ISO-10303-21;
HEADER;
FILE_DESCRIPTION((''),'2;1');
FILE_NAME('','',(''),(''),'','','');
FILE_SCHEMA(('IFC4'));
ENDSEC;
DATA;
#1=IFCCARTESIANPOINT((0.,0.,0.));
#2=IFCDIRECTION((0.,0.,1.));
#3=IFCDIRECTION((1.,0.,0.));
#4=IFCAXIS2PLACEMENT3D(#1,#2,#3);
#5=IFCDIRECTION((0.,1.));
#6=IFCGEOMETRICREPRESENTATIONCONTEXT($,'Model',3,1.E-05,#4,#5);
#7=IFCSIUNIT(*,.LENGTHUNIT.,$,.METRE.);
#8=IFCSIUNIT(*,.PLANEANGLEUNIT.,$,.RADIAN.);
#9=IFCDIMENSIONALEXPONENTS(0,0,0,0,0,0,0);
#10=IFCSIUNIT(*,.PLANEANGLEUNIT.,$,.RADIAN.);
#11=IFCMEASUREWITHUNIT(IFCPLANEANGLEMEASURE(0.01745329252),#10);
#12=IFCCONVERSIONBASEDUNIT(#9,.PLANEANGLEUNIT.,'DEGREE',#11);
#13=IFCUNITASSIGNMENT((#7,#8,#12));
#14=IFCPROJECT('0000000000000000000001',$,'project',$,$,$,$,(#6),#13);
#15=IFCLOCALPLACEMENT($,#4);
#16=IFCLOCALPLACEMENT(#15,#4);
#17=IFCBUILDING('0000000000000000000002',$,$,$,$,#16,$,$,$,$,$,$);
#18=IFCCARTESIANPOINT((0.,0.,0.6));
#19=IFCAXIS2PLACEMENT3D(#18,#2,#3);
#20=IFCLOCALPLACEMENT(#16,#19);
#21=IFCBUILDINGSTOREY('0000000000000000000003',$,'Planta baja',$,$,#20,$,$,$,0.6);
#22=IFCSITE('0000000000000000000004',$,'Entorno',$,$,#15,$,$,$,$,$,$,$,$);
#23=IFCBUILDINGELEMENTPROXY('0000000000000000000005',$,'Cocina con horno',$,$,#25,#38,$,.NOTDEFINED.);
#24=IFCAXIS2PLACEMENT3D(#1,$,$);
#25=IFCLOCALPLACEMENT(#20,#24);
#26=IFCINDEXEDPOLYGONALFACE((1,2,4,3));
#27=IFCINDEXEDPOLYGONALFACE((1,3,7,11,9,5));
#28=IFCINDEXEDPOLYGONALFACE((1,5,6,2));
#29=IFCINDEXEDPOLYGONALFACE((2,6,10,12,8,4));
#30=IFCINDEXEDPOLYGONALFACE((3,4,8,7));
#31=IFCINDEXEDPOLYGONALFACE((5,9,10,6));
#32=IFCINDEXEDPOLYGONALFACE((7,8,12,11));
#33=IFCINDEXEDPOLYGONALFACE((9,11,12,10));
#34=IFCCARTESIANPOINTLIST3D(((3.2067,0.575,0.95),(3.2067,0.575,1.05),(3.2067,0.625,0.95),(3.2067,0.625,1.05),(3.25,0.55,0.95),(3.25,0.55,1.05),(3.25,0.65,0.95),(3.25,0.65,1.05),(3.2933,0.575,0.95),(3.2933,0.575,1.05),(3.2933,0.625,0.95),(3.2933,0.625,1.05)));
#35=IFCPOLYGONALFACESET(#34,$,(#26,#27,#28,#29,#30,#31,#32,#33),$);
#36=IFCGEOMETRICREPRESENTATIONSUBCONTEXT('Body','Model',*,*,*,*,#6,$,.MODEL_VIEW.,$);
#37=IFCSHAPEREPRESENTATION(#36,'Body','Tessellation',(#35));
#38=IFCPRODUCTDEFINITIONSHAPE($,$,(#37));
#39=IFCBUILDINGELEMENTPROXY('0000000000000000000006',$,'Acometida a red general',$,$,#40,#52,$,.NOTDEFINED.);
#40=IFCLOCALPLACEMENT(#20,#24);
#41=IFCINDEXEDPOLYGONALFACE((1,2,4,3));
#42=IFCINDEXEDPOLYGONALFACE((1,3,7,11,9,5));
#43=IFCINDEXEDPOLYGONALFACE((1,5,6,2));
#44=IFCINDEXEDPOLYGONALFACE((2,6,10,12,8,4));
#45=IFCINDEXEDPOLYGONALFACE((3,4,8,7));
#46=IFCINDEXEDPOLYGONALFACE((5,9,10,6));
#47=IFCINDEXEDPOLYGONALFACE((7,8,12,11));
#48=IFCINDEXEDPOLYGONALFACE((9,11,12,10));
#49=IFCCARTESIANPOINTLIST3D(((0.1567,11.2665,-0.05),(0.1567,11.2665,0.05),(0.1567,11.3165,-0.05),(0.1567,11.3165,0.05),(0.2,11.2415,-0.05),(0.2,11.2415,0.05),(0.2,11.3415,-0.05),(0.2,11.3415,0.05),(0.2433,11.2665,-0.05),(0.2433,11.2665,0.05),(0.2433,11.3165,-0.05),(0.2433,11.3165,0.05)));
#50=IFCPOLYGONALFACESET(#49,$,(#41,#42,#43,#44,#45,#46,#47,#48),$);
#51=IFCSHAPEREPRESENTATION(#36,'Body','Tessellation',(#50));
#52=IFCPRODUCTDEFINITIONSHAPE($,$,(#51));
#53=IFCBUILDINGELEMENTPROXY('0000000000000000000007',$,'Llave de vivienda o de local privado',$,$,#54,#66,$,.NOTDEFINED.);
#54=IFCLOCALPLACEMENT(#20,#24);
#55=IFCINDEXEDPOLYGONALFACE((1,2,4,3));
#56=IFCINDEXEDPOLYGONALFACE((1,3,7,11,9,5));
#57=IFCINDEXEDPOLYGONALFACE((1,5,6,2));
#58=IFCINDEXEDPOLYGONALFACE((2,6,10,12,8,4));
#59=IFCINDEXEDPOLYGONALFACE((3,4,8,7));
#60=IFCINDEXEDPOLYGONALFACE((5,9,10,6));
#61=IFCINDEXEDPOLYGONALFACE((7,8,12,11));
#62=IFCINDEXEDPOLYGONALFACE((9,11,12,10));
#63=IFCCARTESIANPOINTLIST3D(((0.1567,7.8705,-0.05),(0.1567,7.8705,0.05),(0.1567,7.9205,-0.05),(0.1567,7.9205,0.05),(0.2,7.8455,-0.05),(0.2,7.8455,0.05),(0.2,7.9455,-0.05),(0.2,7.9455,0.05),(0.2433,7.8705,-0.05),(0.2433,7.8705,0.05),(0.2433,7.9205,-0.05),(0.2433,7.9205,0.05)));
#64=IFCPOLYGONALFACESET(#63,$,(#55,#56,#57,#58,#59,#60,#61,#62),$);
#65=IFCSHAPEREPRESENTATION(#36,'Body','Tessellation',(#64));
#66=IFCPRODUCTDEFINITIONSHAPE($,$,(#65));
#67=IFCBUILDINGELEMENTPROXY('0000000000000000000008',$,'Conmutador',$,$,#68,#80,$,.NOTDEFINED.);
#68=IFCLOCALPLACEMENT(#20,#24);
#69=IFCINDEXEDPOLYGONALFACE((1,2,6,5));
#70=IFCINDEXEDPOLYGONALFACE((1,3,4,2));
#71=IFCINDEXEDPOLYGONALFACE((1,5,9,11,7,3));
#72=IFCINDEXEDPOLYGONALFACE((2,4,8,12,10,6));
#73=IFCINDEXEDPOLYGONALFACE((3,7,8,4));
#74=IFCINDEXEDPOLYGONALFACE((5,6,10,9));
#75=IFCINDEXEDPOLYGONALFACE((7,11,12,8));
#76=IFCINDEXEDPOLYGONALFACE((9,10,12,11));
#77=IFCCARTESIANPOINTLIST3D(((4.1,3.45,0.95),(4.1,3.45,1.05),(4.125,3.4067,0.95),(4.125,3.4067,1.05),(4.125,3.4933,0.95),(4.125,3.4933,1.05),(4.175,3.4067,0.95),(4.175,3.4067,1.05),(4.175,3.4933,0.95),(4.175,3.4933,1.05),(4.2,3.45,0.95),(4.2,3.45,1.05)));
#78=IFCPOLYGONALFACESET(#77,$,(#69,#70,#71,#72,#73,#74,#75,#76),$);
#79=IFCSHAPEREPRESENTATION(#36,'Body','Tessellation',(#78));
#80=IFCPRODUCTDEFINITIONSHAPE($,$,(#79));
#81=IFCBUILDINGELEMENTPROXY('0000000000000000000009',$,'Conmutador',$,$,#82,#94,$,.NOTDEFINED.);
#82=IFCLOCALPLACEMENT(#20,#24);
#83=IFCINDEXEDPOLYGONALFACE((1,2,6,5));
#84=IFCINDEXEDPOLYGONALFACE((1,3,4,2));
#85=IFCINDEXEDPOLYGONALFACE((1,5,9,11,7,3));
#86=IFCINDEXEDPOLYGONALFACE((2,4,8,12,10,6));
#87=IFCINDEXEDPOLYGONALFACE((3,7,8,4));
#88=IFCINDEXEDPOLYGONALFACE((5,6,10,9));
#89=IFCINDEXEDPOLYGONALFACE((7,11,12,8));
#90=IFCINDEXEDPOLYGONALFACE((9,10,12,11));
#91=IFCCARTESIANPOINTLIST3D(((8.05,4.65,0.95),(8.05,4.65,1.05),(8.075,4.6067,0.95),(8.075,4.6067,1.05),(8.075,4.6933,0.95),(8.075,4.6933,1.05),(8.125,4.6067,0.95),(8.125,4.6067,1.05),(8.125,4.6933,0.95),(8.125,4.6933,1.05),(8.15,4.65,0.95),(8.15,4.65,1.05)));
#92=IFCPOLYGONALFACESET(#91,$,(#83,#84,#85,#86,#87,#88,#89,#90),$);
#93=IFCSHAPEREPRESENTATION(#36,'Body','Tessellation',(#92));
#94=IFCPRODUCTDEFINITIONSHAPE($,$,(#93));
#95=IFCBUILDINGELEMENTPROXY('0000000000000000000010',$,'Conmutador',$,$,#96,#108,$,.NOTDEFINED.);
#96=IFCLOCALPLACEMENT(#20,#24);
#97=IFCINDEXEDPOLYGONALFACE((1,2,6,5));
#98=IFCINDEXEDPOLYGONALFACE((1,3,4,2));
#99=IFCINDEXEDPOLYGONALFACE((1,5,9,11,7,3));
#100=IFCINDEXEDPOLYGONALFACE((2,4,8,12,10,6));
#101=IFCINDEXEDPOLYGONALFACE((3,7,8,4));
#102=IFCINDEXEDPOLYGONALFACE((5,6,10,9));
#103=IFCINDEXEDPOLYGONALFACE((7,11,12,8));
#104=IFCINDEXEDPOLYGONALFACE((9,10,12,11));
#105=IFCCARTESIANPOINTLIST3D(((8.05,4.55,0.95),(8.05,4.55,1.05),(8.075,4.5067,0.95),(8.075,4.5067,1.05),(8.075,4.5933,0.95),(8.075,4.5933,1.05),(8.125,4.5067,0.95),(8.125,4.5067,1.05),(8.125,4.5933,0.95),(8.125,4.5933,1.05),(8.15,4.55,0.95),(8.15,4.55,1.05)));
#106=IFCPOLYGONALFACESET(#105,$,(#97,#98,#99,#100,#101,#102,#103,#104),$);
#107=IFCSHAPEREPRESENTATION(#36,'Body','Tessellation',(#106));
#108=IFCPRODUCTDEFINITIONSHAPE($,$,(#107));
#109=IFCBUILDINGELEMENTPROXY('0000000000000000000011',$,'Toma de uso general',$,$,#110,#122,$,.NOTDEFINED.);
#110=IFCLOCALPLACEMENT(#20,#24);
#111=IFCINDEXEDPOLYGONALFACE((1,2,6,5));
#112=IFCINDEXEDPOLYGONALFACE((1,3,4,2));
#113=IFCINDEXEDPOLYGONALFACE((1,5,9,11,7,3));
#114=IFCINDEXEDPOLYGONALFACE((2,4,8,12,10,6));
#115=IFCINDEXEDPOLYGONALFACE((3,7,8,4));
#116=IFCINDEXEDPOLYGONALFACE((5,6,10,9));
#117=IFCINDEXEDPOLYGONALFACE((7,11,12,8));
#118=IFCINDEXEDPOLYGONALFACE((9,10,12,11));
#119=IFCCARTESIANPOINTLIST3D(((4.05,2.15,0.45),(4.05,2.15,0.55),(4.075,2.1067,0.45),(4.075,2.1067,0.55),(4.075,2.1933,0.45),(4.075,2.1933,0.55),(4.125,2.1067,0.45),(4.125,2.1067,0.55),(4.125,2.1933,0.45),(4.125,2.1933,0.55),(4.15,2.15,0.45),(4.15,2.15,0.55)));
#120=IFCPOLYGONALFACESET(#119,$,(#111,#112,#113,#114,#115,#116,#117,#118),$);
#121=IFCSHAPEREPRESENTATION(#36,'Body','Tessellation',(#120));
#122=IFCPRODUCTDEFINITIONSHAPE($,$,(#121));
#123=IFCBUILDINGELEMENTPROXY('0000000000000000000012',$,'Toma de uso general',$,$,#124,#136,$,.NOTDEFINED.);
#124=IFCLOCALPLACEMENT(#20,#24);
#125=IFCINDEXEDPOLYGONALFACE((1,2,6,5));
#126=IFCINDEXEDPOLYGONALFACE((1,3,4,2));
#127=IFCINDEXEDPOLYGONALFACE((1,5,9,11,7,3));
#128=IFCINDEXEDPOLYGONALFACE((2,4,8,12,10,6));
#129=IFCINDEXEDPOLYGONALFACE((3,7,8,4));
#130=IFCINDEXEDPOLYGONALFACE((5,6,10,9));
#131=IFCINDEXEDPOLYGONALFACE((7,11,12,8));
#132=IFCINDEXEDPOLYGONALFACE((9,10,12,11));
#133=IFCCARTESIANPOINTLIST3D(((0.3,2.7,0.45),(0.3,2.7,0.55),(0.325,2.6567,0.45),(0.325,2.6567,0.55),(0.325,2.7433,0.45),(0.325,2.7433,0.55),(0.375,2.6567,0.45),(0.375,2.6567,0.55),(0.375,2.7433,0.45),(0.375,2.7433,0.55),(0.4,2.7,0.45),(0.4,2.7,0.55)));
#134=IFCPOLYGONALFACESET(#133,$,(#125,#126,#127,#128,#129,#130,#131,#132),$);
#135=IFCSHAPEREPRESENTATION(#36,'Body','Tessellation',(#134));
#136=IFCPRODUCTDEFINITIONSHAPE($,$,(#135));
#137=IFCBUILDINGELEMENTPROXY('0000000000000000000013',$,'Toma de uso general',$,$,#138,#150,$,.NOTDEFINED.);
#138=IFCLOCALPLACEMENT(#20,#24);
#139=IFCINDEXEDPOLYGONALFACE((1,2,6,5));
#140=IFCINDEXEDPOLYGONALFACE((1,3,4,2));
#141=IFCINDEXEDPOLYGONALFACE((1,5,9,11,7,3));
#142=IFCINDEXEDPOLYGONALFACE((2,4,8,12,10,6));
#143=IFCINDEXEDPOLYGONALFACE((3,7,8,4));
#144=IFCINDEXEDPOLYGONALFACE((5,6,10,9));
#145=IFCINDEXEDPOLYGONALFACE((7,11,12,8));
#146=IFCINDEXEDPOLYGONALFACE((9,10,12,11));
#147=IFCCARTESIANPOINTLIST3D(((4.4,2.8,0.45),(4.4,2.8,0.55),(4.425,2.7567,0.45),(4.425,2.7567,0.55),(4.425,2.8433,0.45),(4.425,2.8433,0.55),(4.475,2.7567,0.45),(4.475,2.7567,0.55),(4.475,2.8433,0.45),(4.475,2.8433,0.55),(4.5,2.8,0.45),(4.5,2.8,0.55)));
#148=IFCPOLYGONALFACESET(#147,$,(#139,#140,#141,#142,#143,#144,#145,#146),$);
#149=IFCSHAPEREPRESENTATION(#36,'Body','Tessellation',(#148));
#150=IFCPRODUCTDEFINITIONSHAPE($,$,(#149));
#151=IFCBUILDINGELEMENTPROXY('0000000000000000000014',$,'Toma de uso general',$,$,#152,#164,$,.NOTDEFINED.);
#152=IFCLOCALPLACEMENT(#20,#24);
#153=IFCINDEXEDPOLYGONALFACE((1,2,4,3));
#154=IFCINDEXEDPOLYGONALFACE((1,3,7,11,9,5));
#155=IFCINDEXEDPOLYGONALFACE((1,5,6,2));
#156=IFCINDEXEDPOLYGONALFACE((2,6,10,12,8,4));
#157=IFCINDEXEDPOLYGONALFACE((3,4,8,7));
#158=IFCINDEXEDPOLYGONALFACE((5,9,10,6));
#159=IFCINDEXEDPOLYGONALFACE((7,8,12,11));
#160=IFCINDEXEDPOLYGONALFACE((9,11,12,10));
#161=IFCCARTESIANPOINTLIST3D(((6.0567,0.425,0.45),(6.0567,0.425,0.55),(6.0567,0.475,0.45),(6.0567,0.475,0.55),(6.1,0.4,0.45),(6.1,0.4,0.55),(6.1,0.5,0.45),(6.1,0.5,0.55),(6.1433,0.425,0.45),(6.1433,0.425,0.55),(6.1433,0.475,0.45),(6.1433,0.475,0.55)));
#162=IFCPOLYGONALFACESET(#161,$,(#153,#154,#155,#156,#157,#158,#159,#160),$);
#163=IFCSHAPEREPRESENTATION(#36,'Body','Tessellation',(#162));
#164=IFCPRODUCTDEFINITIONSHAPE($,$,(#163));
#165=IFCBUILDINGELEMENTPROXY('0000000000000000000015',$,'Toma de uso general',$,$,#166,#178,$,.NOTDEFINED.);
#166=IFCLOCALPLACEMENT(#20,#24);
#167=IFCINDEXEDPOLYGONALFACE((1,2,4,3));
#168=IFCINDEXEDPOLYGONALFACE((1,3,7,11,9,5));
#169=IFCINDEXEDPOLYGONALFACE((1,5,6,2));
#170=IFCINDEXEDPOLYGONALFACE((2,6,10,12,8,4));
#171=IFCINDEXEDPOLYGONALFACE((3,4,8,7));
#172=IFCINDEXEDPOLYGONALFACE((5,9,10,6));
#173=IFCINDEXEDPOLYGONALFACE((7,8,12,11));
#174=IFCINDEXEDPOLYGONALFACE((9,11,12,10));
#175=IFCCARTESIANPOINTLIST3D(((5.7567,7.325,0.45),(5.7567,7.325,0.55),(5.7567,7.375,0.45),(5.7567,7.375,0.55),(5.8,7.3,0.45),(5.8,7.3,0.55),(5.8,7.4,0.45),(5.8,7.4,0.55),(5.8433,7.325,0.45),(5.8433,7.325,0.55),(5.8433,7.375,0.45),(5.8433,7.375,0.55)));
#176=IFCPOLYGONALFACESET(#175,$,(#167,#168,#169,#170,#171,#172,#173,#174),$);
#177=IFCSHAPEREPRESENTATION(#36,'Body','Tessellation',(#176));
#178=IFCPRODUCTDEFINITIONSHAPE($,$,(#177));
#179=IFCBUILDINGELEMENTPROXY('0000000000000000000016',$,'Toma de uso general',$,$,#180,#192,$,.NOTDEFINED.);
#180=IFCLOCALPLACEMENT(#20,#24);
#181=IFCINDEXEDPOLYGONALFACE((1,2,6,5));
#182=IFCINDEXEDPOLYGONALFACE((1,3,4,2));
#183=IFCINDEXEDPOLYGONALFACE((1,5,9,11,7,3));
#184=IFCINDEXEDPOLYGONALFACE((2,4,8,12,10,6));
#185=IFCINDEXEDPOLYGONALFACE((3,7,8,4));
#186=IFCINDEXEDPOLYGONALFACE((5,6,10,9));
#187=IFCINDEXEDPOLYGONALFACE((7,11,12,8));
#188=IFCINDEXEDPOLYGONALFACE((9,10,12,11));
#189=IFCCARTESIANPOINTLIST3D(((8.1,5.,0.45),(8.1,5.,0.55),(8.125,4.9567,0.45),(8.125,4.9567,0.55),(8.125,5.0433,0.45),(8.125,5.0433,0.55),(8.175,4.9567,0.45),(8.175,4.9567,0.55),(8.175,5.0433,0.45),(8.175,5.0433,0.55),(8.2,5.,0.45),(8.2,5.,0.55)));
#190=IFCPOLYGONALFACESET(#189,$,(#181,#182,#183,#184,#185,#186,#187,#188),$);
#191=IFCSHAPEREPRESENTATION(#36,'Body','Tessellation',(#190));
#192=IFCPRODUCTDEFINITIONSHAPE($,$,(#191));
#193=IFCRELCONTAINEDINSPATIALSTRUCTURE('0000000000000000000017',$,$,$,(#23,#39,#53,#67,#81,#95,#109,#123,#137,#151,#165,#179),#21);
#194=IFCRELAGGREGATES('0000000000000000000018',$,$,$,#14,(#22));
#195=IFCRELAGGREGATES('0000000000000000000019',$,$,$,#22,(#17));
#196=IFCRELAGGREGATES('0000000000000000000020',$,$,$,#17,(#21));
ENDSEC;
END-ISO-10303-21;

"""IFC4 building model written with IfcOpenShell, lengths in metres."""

from ifc_helpers import new_model, entity, si_unit, converted_unit, direction, frame, origin_with_axes, place, context, subcontext, project, spatial, polyline, outline, extrude, source, transform, mapped, element, save


model = new_model("IFC4")

# Units and contexts
model_context = context("Model", 3, precision=1e-05, world=origin_with_axes(), true_north=direction((0.0, 1.0)))
body_context = subcontext(model_context, "Body", "Model", "MODEL_VIEW")
ifc_project = project(units=[si_unit("LENGTHUNIT", "METRE"), si_unit("PLANEANGLEUNIT", "RADIAN"), converted_unit("PLANEANGLEUNIT", "DEGREE", entity("IfcPlaneAngleMeasure", 0.01745329252), si_unit("PLANEANGLEUNIT", "RADIAN"), dimensions=[0, 0, 0, 0, 0, 0, 0])], contexts=[model_context])

# Site, building, storey
site_placement = place(None, origin_with_axes())
site = spatial("IfcSite", under=ifc_project, at=site_placement, Name="Entorno")
building_placement = place(site_placement, origin_with_axes())
building = spatial("IfcBuilding", under=site, at=building_placement)
storey_placement = place(building_placement, frame((0.0, 0.0, 0.6), z_axis=(0.0, 0.0, 1.0), x_axis=(1.0, 0.0, 0.0)))
storey = spatial("IfcBuildingStorey", under=building, at=storey_placement, Name="Planta baja", Elevation=0.6)

# Building element proxies
shared_shape_1 = source(origin_with_axes(), body_context, "Body", "SolidModel", [
    extrude(outline(polyline([(0.05, 0.0), (0.025, 0.0433), (-0.025, 0.0433), (-0.05, 0.0), (-0.025, -0.0433), (0.025, -0.0433), (0.05, 0.0)])), frame((0.0, 0.0, -0.05), z_axis=(0.0, 0.0, 1.0), x_axis=(1.0, 0.0, 0.0)), (0.0, 0.0, 1.0), 0.1),
])
proxy_1_placement = place(storey_placement, frame((0.0, 0.0, -0.6), z_axis=(0.0, 0.0, 1.0), x_axis=(1.0, 0.0, 0.0)))
element("IfcBuildingElementProxy", 1, at=proxy_1_placement, inside=storey, Name="Cocina con horno", PredefinedType="NOTDEFINED", context=body_context, shape_type="Brep", body=[
    mapped(shared_shape_1, transform((3.25, 0.6, 1.6), x_axis=(0.0, 1.0, 0.0), y_axis=(-1.0, 0.0, 0.0), z_axis=(0.0, 0.0, 1.0))),
])
shared_shape_2 = source(origin_with_axes(), body_context, "Body", "SolidModel", [
    extrude(outline(polyline([(0.05, 0.0), (0.025, 0.0433), (-0.025, 0.0433), (-0.05, 0.0), (-0.025, -0.0433), (0.025, -0.0433), (0.05, 0.0)])), frame((0.0, 0.0, -0.05), z_axis=(0.0, 0.0, 1.0), x_axis=(1.0, 0.0, 0.0)), (0.0, 0.0, 1.0), 0.1),
])
proxy_2_placement = place(storey_placement, frame((0.0, 0.0, -0.6), z_axis=(0.0, 0.0, 1.0), x_axis=(1.0, 0.0, 0.0)))
element("IfcBuildingElementProxy", 2, at=proxy_2_placement, inside=storey, Name="Acometida a red general", PredefinedType="NOTDEFINED", context=body_context, shape_type="Brep", body=[
    mapped(shared_shape_2, transform((0.2, 11.2915, 0.6), x_axis=(0.0, -1.0, 0.0), y_axis=(1.0, 0.0, 0.0), z_axis=(0.0, 0.0, 1.0))),
])
shared_shape_3 = source(origin_with_axes(), body_context, "Body", "SolidModel", [
    extrude(outline(polyline([(0.05, 0.0), (0.025, 0.0433), (-0.025, 0.0433), (-0.05, 0.0), (-0.025, -0.0433), (0.025, -0.0433), (0.05, 0.0)])), frame((0.0, 0.0, -0.05), z_axis=(0.0, 0.0, 1.0), x_axis=(1.0, 0.0, 0.0)), (0.0, 0.0, 1.0), 0.1),
])
proxy_3_placement = place(storey_placement, frame((0.0, 0.0, -0.6), z_axis=(0.0, 0.0, 1.0), x_axis=(1.0, 0.0, 0.0)))
element("IfcBuildingElementProxy", 3, at=proxy_3_placement, inside=storey, Name="Llave de vivienda o de local privado", PredefinedType="NOTDEFINED", context=body_context, shape_type="Brep", body=[
    mapped(shared_shape_3, transform((0.2, 7.8955, 0.6), x_axis=(0.0, -1.0, 0.0), y_axis=(1.0, 0.0, 0.0), z_axis=(0.0, 0.0, 1.0))),
])
shared_shape_4 = source(origin_with_axes(), body_context, "Body", "SolidModel", [
    extrude(outline(polyline([(0.05, 0.0), (0.025, 0.0433), (-0.025, 0.0433), (-0.05, 0.0), (-0.025, -0.0433), (0.025, -0.0433), (0.05, 0.0)])), frame((0.0, 0.0, -0.05), z_axis=(0.0, 0.0, 1.0), x_axis=(1.0, 0.0, 0.0)), (0.0, 0.0, 1.0), 0.1),
])
proxy_4_placement = place(storey_placement, frame((0.0, 0.0, -0.6), z_axis=(0.0, 0.0, 1.0), x_axis=(1.0, 0.0, 0.0)))
element("IfcBuildingElementProxy", 4, at=proxy_4_placement, inside=storey, Name="Conmutador", PredefinedType="NOTDEFINED", context=body_context, shape_type="Brep", body=[
    mapped(shared_shape_4, transform((4.15, 3.45, 1.6), x_axis=(1.0, 0.0, 0.0), y_axis=(0.0, 1.0, 0.0), z_axis=(0.0, 0.0, 1.0))),
])
proxy_5_placement = place(storey_placement, frame((0.0, 0.0, -0.6), z_axis=(0.0, 0.0, 1.0), x_axis=(1.0, 0.0, 0.0)))
element("IfcBuildingElementProxy", 5, at=proxy_5_placement, inside=storey, Name="Conmutador", PredefinedType="NOTDEFINED", context=body_context, shape_type="Brep", body=[
    mapped(shared_shape_4, transform((8.1, 4.65, 1.6), x_axis=(1.0, 0.0, 0.0), y_axis=(0.0, 1.0, 0.0), z_axis=(0.0, 0.0, 1.0))),
])
proxy_6_placement = place(storey_placement, frame((0.0, 0.0, -0.6), z_axis=(0.0, 0.0, 1.0), x_axis=(1.0, 0.0, 0.0)))
element("IfcBuildingElementProxy", 6, at=proxy_6_placement, inside=storey, Name="Conmutador", PredefinedType="NOTDEFINED", context=body_context, shape_type="Brep", body=[
    mapped(shared_shape_4, transform((8.1, 4.55, 1.6), x_axis=(1.0, 0.0, 0.0), y_axis=(0.0, 1.0, 0.0), z_axis=(0.0, 0.0, 1.0))),
])
shared_shape_5 = source(origin_with_axes(), body_context, "Body", "SolidModel", [
    extrude(outline(polyline([(0.05, 0.0), (0.025, 0.0433), (-0.025, 0.0433), (-0.05, 0.0), (-0.025, -0.0433), (0.025, -0.0433), (0.05, 0.0)])), frame((0.0, 0.0, -0.05), z_axis=(0.0, 0.0, 1.0), x_axis=(1.0, 0.0, 0.0)), (0.0, 0.0, 1.0), 0.1),
])
proxy_7_placement = place(storey_placement, frame((0.0, 0.0, -0.6), z_axis=(0.0, 0.0, 1.0), x_axis=(1.0, 0.0, 0.0)))
element("IfcBuildingElementProxy", 7, at=proxy_7_placement, inside=storey, Name="Toma de uso general", PredefinedType="NOTDEFINED", context=body_context, shape_type="Brep", body=[
    mapped(shared_shape_5, transform((4.1, 2.15, 1.1), x_axis=(-1.0, 0.0, 0.0), y_axis=(0.0, -1.0, 0.0), z_axis=(0.0, 0.0, 1.0))),
])
proxy_8_placement = place(storey_placement, frame((0.0, 0.0, -0.6), z_axis=(0.0, 0.0, 1.0), x_axis=(1.0, 0.0, 0.0)))
element("IfcBuildingElementProxy", 8, at=proxy_8_placement, inside=storey, Name="Toma de uso general", PredefinedType="NOTDEFINED", context=body_context, shape_type="Brep", body=[
    mapped(shared_shape_5, transform((0.35, 2.7, 1.1), x_axis=(1.0, 0.0, 0.0), y_axis=(0.0, 1.0, 0.0), z_axis=(0.0, 0.0, 1.0))),
])
proxy_9_placement = place(storey_placement, frame((0.0, 0.0, -0.6), z_axis=(0.0, 0.0, 1.0), x_axis=(1.0, 0.0, 0.0)))
element("IfcBuildingElementProxy", 9, at=proxy_9_placement, inside=storey, Name="Toma de uso general", PredefinedType="NOTDEFINED", context=body_context, shape_type="Brep", body=[
    mapped(shared_shape_5, transform((4.45, 2.8, 1.1), x_axis=(1.0, 0.0, 0.0), y_axis=(0.0, 1.0, 0.0), z_axis=(0.0, 0.0, 1.0))),
])
proxy_10_placement = place(storey_placement, frame((0.0, 0.0, -0.6), z_axis=(0.0, 0.0, 1.0), x_axis=(1.0, 0.0, 0.0)))
element("IfcBuildingElementProxy", 10, at=proxy_10_placement, inside=storey, Name="Toma de uso general", PredefinedType="NOTDEFINED", context=body_context, shape_type="Brep", body=[
    mapped(shared_shape_5, transform((6.1, 0.45, 1.1), x_axis=(0.0, 1.0, 0.0), y_axis=(-1.0, 0.0, 0.0), z_axis=(0.0, 0.0, 1.0))),
])
proxy_11_placement = place(storey_placement, frame((0.0, 0.0, -0.6), z_axis=(0.0, 0.0, 1.0), x_axis=(1.0, 0.0, 0.0)))
element("IfcBuildingElementProxy", 11, at=proxy_11_placement, inside=storey, Name="Toma de uso general", PredefinedType="NOTDEFINED", context=body_context, shape_type="Brep", body=[
    mapped(shared_shape_5, transform((5.8, 7.35, 1.1), x_axis=(0.0, -1.0, 0.0), y_axis=(1.0, 0.0, 0.0), z_axis=(0.0, 0.0, 1.0))),
])
proxy_12_placement = place(storey_placement, frame((0.0, 0.0, -0.6), z_axis=(0.0, 0.0, 1.0), x_axis=(1.0, 0.0, 0.0)))
element("IfcBuildingElementProxy", 12, at=proxy_12_placement, inside=storey, Name="Toma de uso general", PredefinedType="NOTDEFINED", context=body_context, shape_type="Brep", body=[
    mapped(shared_shape_5, transform((8.15, 5.0, 1.1), x_axis=(-1.0, 0.0, 0.0), y_axis=(0.0, -1.0, 0.0), z_axis=(0.0, 0.0, 1.0))),
])

save(model, "model.ifc")
